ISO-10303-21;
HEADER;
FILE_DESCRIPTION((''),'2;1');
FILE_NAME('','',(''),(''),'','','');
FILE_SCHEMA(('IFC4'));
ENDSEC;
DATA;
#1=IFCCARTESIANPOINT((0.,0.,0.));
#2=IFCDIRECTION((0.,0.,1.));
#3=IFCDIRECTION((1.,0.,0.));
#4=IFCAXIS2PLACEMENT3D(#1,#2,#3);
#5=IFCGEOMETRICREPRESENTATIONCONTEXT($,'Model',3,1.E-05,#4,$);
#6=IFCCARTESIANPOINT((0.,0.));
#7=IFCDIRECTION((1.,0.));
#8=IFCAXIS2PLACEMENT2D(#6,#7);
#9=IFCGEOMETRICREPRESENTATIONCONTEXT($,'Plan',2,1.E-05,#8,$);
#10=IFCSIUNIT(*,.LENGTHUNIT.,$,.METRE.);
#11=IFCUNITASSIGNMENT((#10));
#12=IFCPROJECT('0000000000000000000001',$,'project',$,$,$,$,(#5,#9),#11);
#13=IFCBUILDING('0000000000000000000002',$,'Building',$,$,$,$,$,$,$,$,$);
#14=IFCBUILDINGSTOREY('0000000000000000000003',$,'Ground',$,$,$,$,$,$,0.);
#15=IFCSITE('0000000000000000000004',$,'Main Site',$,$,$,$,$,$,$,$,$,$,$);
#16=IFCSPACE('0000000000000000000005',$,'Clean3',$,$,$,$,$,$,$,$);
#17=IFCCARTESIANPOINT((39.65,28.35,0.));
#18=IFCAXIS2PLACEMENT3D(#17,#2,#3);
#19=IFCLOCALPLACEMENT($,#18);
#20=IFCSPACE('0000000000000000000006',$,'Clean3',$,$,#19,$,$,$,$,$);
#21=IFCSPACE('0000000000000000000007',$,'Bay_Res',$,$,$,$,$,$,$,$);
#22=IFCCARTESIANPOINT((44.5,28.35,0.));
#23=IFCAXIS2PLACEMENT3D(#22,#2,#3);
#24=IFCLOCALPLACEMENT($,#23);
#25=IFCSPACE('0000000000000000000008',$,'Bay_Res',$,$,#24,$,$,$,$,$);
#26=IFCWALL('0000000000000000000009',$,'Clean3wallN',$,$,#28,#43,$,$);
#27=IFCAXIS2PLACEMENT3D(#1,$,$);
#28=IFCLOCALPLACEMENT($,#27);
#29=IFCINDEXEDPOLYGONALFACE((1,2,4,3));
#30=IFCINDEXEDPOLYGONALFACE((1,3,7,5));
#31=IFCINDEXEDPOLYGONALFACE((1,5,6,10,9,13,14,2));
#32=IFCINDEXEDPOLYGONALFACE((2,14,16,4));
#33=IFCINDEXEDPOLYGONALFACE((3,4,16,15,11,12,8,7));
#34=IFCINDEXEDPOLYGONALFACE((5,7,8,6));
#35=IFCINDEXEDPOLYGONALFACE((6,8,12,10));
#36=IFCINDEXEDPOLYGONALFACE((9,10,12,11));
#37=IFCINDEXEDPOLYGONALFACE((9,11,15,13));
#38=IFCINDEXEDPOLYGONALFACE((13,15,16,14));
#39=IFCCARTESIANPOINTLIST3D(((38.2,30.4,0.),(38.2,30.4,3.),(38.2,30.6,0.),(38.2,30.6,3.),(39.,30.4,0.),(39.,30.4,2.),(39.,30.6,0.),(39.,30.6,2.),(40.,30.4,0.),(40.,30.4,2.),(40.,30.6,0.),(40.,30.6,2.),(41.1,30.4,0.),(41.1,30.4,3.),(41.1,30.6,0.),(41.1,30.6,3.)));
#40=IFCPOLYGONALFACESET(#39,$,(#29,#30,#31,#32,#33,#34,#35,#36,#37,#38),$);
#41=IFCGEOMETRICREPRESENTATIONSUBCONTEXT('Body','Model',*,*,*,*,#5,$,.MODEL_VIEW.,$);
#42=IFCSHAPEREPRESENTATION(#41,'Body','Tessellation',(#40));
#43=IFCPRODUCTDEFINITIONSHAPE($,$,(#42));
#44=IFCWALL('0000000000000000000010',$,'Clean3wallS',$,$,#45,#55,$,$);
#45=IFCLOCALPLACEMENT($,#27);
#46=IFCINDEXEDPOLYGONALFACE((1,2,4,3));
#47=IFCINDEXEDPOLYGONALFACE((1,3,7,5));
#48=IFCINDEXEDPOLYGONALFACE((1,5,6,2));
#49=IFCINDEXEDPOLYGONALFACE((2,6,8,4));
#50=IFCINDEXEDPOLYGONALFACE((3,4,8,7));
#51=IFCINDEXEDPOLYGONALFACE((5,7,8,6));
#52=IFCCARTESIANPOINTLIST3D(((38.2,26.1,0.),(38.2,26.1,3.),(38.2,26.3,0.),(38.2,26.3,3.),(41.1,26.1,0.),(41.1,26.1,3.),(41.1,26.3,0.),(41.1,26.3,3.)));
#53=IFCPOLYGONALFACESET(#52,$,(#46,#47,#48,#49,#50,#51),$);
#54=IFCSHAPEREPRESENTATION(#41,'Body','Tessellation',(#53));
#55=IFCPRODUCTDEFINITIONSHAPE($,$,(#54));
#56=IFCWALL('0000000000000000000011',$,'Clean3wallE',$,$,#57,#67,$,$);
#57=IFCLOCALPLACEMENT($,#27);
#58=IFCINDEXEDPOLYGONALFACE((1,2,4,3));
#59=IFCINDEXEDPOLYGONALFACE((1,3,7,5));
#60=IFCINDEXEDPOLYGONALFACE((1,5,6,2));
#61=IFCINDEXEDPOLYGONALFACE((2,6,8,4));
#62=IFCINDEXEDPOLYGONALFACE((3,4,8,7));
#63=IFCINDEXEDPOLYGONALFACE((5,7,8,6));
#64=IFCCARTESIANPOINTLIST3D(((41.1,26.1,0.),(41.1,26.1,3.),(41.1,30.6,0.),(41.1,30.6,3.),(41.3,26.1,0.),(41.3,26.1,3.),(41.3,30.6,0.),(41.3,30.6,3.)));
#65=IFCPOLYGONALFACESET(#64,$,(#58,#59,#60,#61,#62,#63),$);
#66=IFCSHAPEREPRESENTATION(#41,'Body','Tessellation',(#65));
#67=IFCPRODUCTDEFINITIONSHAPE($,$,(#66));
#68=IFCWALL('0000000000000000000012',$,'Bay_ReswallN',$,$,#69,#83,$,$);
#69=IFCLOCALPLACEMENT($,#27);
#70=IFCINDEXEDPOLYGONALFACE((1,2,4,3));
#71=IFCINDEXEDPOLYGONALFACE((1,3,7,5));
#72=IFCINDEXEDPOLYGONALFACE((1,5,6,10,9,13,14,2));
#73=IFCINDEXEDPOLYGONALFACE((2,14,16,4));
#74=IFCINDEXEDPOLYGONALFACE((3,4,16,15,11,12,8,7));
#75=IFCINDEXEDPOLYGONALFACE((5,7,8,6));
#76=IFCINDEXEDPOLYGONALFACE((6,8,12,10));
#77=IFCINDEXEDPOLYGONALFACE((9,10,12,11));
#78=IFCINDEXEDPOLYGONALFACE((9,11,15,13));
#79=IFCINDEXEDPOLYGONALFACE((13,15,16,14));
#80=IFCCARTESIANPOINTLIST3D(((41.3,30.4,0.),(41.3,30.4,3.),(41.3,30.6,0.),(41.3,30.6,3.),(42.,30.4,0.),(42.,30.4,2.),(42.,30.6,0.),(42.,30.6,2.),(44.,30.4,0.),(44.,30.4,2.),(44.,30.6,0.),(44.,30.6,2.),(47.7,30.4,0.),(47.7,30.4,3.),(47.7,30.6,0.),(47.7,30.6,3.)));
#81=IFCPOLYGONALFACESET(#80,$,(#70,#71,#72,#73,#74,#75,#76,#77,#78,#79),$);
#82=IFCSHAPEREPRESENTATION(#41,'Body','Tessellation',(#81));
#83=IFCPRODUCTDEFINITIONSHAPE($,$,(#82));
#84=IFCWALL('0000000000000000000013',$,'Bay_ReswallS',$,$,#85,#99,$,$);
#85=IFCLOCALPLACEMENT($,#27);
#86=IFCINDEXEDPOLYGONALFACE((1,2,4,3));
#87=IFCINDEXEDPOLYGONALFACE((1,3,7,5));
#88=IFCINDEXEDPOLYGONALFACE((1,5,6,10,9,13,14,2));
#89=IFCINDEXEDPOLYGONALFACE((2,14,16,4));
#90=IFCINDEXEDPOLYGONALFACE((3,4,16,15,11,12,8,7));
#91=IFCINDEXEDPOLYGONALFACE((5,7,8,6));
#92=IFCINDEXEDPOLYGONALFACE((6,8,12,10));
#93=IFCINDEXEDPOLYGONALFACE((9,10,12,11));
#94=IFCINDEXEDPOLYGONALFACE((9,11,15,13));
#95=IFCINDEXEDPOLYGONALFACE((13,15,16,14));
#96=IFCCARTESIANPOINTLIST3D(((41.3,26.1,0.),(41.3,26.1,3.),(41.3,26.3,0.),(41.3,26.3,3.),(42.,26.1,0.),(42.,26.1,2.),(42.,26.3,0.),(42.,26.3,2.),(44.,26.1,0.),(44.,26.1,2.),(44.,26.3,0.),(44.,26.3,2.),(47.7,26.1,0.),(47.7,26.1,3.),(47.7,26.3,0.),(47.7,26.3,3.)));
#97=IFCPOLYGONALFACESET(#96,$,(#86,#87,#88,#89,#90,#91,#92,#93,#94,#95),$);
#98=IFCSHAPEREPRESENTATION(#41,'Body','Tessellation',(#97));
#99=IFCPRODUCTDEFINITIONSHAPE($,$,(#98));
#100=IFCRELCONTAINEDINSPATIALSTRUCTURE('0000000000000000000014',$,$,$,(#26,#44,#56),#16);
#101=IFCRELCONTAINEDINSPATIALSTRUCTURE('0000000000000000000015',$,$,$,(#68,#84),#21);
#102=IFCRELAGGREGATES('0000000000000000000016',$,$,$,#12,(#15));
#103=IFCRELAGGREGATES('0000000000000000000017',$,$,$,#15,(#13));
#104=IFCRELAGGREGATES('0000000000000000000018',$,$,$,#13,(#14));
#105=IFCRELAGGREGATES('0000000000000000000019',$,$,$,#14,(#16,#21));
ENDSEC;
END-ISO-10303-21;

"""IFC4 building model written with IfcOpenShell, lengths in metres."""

from ifc_helpers import new_model, si_unit, frame, origin_with_axes, origin_2d_with_axis, place, context, subcontext, project, spatial, indexed_curve, outline, extrude, element, save


model = new_model("IFC4")

# Units and contexts
model_context = context("Model", 3, precision=1e-05, world=origin_with_axes())
plan_context = context("Plan", 2, precision=1e-05, world=origin_2d_with_axis())
body_context = subcontext(model_context, "Body", "Model", "MODEL_VIEW")
ifc_project = project(units=[si_unit("LENGTHUNIT", "METRE")], contexts=[model_context, plan_context])

# Site, building, storey
site = spatial("IfcSite", under=ifc_project, Name="Main Site")
building = spatial("IfcBuilding", under=site, Name="Building")
storey = spatial("IfcBuildingStorey", under=building, Name="Ground", Elevation=0.0)

# Shared definitions
space_1 = spatial("IfcSpace", under=storey, Name="Clean3")

# Wall
wall_1_placement = place(None, frame((38.2, 30.4, 0.0), z_axis=(0.0, 0.0, 1.0), x_axis=(1.0, 0.0, 0.0)))
wall_1 = element("IfcWall", 1, at=wall_1_placement, inside=space_1, Name="Clean3wallN", context=body_context, shape_type="SweptSolid", body=[
    extrude(outline(indexed_curve([(0.0, 0.0), (0.0, 0.2), (2.9, 0.2), (2.9, 0.0), (0.0, 0.0)], self_intersect=False)), origin_with_axes(), (0.0, 0.0, 1.0), 3.0),
])

# Shared definitions
space_2_placement = place(None, frame((39.65, 28.35, 0.0), z_axis=(0.0, 0.0, 1.0), x_axis=(1.0, 0.0, 0.0)))
space_2 = spatial("IfcSpace", at=space_2_placement, Name="Clean3")

# Opening
opening_1_placement = place(wall_1_placement, frame((0.8, 0.0, 0.0), z_axis=(0.0, 0.0, 1.0), x_axis=(1.0, 0.0, 0.0)))
element("IfcOpeningElement", 2, at=opening_1_placement, inside=space_2, cuts=wall_1, context=body_context, shape_type="SweptSolid", body=[
    extrude(outline(indexed_curve([(0.0, 0.0), (0.0, 0.4), (1.0, 0.4), (1.0, 0.0), (0.0, 0.0)], self_intersect=False)), origin_with_axes(), (0.0, 0.0, 1.0), 2.0),
])

# Walls
wall_2_placement = place(None, frame((38.2, 26.1, 0.0), z_axis=(0.0, 0.0, 1.0), x_axis=(1.0, 0.0, 0.0)))
element("IfcWall", 3, at=wall_2_placement, inside=space_1, Name="Clean3wallS", context=body_context, shape_type="SweptSolid", body=[
    extrude(outline(indexed_curve([(0.0, 0.0), (0.0, 0.2), (2.9, 0.2), (2.9, 0.0), (0.0, 0.0)], self_intersect=False)), origin_with_axes(), (0.0, 0.0, 1.0), 3.0),
])
for number, where, z_axis, x_axis, name in (
    (4, (41.3, 26.1, 0.0), (0.0, 0.0, 1.0), (0.0, 1.0, 0.0), "Clean3wallE"),
):
    element("IfcWall", number, at=place(None, frame(where, z_axis=z_axis, x_axis=x_axis)), inside=space_1, Name=name, context=body_context, shape_type="SweptSolid", body=[
        extrude(outline(indexed_curve([(0.0, 0.0), (0.0, 0.2), (4.5, 0.2), (4.5, 0.0), (0.0, 0.0)], self_intersect=False)), origin_with_axes(), (0.0, 0.0, 1.0), 3.0),
    ])

# Shared definitions
space_3 = spatial("IfcSpace", under=storey, Name="Bay_Res")

# Wall
wall_3_placement = place(None, frame((41.3, 30.4, 0.0), z_axis=(0.0, 0.0, 1.0), x_axis=(1.0, 0.0, 0.0)))
wall_3 = element("IfcWall", 5, at=wall_3_placement, inside=space_3, Name="Bay_ReswallN", context=body_context, shape_type="SweptSolid", body=[
    extrude(outline(indexed_curve([(0.0, 0.0), (0.0, 0.2), (6.4, 0.2), (6.4, 0.0), (0.0, 0.0)], self_intersect=False)), origin_with_axes(), (0.0, 0.0, 1.0), 3.0),
])

# Shared definitions
space_4_placement = place(None, frame((44.5, 28.35, 0.0), z_axis=(0.0, 0.0, 1.0), x_axis=(1.0, 0.0, 0.0)))
space_4 = spatial("IfcSpace", at=space_4_placement, Name="Bay_Res")

# Opening
opening_2_placement = place(wall_3_placement, frame((0.7, 0.0, 0.0), z_axis=(0.0, 0.0, 1.0), x_axis=(1.0, 0.0, 0.0)))
element("IfcOpeningElement", 6, at=opening_2_placement, inside=space_4, cuts=wall_3, context=body_context, shape_type="SweptSolid", body=[
    extrude(outline(indexed_curve([(0.0, 0.0), (0.0, 0.4), (2.0, 0.4), (2.0, 0.0), (0.0, 0.0)], self_intersect=False)), origin_with_axes(), (0.0, 0.0, 1.0), 2.0),
])

# Wall, opening
wall_4_placement = place(None, frame((41.3, 26.1, 0.0), z_axis=(0.0, 0.0, 1.0), x_axis=(1.0, 0.0, 0.0)))
wall_4 = element("IfcWall", 7, at=wall_4_placement, inside=space_3, Name="Bay_ReswallS", context=body_context, shape_type="SweptSolid", body=[
    extrude(outline(indexed_curve([(0.0, 0.0), (0.0, 0.2), (6.4, 0.2), (6.4, 0.0), (0.0, 0.0)], self_intersect=False)), origin_with_axes(), (0.0, 0.0, 1.0), 3.0),
])
opening_3_placement = place(wall_4_placement, frame((0.7, 0.0, 0.0), z_axis=(0.0, 0.0, 1.0), x_axis=(1.0, 0.0, 0.0)))
element("IfcOpeningElement", 8, at=opening_3_placement, inside=space_4, cuts=wall_4, context=body_context, shape_type="SweptSolid", body=[
    extrude(outline(indexed_curve([(0.0, 0.0), (0.0, 0.4), (2.0, 0.4), (2.0, 0.0), (0.0, 0.0)], self_intersect=False)), origin_with_axes(), (0.0, 0.0, 1.0), 2.0),
])

save(model, "model.ifc")
